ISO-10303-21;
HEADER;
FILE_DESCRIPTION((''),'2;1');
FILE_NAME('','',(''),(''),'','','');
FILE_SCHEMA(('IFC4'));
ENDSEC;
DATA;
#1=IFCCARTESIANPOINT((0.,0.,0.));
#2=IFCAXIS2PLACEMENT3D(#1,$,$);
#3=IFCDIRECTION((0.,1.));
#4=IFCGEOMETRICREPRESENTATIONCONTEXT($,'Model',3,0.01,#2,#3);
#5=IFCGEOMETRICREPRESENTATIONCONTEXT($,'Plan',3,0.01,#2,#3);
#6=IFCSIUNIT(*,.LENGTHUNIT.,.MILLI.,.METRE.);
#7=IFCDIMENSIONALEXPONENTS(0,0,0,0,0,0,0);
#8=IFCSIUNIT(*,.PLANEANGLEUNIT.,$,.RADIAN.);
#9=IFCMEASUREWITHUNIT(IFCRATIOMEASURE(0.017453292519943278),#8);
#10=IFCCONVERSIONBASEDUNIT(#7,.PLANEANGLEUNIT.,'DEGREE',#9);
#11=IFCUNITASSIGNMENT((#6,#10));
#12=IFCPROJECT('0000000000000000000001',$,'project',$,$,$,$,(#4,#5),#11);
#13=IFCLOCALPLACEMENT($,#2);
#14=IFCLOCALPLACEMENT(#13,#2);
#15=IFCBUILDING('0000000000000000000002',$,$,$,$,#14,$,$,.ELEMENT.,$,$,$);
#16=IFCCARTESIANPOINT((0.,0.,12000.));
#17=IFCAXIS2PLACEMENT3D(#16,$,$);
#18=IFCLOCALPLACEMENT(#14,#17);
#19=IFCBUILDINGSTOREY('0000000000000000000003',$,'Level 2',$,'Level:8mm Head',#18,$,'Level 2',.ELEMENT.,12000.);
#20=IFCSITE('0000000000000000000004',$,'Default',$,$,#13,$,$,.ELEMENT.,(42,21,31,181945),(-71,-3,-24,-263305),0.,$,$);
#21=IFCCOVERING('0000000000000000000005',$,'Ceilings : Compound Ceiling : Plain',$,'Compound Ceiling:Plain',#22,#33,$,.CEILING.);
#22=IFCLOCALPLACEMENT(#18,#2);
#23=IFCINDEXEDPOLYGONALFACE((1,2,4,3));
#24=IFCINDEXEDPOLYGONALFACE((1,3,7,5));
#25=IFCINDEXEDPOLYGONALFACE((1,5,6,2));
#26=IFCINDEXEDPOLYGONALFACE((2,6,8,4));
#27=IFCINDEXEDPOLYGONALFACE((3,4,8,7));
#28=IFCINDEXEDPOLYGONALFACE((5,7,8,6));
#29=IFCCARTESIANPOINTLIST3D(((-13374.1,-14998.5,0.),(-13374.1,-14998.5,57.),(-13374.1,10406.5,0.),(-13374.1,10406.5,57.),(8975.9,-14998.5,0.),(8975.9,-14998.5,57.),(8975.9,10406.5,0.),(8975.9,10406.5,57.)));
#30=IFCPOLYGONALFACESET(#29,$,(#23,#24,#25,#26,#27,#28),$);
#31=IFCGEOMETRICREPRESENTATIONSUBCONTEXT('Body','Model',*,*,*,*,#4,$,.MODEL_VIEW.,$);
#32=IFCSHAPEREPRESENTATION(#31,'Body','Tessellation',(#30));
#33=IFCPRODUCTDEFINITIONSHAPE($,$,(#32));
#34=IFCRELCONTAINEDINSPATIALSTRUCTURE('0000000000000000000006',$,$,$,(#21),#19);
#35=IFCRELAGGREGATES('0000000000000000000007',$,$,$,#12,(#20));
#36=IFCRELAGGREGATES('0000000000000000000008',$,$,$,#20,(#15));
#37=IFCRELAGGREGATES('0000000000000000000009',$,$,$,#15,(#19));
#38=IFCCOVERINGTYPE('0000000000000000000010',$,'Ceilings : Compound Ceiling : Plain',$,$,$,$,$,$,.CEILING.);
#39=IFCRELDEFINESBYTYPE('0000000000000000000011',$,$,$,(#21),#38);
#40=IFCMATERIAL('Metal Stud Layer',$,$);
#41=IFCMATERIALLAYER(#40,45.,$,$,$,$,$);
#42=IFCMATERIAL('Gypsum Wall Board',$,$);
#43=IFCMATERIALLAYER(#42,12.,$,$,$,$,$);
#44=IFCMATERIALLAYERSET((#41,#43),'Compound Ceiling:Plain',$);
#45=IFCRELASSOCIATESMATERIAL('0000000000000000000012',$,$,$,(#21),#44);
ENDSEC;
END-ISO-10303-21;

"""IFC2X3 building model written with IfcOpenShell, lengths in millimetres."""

from ifc_helpers import new_model, entity, si_unit, converted_unit, direction, frame, frame_2d, origin, place, context, subcontext, project, spatial, rectangle, extrude, material, layer, layer_set, layer_usage, type_object, element, save


model = new_model("IFC2X3")

# Units and contexts
model_context = context("Model", 3, precision=0.01, world=origin(), true_north=direction((0.0, 1.0)))
plan_context = context("Plan", 3, precision=0.01, world=origin(), true_north=direction((0.0, 1.0)))
body_context = subcontext(model_context, "Body", "Model", "MODEL_VIEW")
ifc_project = project(units=[si_unit("LENGTHUNIT", "METRE", prefix="MILLI"), converted_unit("PLANEANGLEUNIT", "DEGREE", entity("IfcRatioMeasure", 0.017453292519943278), si_unit("PLANEANGLEUNIT", "RADIAN"), dimensions=[0, 0, 0, 0, 0, 0, 0])], contexts=[model_context, plan_context])

# Site, building, storey
site_placement = place(None, origin())
site = spatial("IfcSite", under=ifc_project, at=site_placement, Name="Default", CompositionType="ELEMENT", RefLatitude=(42, 21, 31, 181945), RefLongitude=(-71, -3, -24, -263305), RefElevation=0.0)
building_placement = place(site_placement, origin())
building = spatial("IfcBuilding", under=site, at=building_placement, CompositionType="ELEMENT")
storey_placement = place(building_placement, frame((0.0, 0.0, 12000.0)))
storey = spatial("IfcBuildingStorey", under=building, at=storey_placement, Name="Level 2", ObjectType="Level:8mm Head", LongName="Level 2", CompositionType="ELEMENT", Elevation=12000.0)

# Covering
ifc_material_1 = material(Name="Metal Stud Layer")
ifc_layer_1 = layer(ifc_material_1, 45.0)
ifc_material_2 = material(Name="Gypsum Wall Board")
ifc_layer_2 = layer(ifc_material_2, 12.0)
ifc_layer_set = layer_set([ifc_layer_1, ifc_layer_2], Name="Compound Ceiling:Plain")
ifc_layer_usage = layer_usage(ifc_layer_set, "AXIS3", "POSITIVE", 0.0)
covering_type = type_object("IfcCoveringType", Name="Ceilings : Compound Ceiling : Plain", PredefinedType="CEILING")
covering_placement = place(storey_placement, frame((-13374.1, -14998.5, 0.0)))
element("IfcCovering", 1, at=covering_placement, inside=storey, type_object=covering_type, material=ifc_layer_usage, Name="Ceilings : Compound Ceiling : Plain", ObjectType="Compound Ceiling:Plain", PredefinedType="CEILING", context=body_context, shape_type="SweptSolid", body=[
    extrude(rectangle(XDim=22350.0, YDim=25405.0, at=frame_2d((0.0, 0.0), x_axis=(1.0, 0.0))), frame((11175.0, 12702.5, 0.0), z_axis=(0.0, 0.0, 1.0), x_axis=(-1.0, 0.0, 0.0)), (0.0, 0.0, 1.0), 57.0),
])

save(model, "model.ifc")
